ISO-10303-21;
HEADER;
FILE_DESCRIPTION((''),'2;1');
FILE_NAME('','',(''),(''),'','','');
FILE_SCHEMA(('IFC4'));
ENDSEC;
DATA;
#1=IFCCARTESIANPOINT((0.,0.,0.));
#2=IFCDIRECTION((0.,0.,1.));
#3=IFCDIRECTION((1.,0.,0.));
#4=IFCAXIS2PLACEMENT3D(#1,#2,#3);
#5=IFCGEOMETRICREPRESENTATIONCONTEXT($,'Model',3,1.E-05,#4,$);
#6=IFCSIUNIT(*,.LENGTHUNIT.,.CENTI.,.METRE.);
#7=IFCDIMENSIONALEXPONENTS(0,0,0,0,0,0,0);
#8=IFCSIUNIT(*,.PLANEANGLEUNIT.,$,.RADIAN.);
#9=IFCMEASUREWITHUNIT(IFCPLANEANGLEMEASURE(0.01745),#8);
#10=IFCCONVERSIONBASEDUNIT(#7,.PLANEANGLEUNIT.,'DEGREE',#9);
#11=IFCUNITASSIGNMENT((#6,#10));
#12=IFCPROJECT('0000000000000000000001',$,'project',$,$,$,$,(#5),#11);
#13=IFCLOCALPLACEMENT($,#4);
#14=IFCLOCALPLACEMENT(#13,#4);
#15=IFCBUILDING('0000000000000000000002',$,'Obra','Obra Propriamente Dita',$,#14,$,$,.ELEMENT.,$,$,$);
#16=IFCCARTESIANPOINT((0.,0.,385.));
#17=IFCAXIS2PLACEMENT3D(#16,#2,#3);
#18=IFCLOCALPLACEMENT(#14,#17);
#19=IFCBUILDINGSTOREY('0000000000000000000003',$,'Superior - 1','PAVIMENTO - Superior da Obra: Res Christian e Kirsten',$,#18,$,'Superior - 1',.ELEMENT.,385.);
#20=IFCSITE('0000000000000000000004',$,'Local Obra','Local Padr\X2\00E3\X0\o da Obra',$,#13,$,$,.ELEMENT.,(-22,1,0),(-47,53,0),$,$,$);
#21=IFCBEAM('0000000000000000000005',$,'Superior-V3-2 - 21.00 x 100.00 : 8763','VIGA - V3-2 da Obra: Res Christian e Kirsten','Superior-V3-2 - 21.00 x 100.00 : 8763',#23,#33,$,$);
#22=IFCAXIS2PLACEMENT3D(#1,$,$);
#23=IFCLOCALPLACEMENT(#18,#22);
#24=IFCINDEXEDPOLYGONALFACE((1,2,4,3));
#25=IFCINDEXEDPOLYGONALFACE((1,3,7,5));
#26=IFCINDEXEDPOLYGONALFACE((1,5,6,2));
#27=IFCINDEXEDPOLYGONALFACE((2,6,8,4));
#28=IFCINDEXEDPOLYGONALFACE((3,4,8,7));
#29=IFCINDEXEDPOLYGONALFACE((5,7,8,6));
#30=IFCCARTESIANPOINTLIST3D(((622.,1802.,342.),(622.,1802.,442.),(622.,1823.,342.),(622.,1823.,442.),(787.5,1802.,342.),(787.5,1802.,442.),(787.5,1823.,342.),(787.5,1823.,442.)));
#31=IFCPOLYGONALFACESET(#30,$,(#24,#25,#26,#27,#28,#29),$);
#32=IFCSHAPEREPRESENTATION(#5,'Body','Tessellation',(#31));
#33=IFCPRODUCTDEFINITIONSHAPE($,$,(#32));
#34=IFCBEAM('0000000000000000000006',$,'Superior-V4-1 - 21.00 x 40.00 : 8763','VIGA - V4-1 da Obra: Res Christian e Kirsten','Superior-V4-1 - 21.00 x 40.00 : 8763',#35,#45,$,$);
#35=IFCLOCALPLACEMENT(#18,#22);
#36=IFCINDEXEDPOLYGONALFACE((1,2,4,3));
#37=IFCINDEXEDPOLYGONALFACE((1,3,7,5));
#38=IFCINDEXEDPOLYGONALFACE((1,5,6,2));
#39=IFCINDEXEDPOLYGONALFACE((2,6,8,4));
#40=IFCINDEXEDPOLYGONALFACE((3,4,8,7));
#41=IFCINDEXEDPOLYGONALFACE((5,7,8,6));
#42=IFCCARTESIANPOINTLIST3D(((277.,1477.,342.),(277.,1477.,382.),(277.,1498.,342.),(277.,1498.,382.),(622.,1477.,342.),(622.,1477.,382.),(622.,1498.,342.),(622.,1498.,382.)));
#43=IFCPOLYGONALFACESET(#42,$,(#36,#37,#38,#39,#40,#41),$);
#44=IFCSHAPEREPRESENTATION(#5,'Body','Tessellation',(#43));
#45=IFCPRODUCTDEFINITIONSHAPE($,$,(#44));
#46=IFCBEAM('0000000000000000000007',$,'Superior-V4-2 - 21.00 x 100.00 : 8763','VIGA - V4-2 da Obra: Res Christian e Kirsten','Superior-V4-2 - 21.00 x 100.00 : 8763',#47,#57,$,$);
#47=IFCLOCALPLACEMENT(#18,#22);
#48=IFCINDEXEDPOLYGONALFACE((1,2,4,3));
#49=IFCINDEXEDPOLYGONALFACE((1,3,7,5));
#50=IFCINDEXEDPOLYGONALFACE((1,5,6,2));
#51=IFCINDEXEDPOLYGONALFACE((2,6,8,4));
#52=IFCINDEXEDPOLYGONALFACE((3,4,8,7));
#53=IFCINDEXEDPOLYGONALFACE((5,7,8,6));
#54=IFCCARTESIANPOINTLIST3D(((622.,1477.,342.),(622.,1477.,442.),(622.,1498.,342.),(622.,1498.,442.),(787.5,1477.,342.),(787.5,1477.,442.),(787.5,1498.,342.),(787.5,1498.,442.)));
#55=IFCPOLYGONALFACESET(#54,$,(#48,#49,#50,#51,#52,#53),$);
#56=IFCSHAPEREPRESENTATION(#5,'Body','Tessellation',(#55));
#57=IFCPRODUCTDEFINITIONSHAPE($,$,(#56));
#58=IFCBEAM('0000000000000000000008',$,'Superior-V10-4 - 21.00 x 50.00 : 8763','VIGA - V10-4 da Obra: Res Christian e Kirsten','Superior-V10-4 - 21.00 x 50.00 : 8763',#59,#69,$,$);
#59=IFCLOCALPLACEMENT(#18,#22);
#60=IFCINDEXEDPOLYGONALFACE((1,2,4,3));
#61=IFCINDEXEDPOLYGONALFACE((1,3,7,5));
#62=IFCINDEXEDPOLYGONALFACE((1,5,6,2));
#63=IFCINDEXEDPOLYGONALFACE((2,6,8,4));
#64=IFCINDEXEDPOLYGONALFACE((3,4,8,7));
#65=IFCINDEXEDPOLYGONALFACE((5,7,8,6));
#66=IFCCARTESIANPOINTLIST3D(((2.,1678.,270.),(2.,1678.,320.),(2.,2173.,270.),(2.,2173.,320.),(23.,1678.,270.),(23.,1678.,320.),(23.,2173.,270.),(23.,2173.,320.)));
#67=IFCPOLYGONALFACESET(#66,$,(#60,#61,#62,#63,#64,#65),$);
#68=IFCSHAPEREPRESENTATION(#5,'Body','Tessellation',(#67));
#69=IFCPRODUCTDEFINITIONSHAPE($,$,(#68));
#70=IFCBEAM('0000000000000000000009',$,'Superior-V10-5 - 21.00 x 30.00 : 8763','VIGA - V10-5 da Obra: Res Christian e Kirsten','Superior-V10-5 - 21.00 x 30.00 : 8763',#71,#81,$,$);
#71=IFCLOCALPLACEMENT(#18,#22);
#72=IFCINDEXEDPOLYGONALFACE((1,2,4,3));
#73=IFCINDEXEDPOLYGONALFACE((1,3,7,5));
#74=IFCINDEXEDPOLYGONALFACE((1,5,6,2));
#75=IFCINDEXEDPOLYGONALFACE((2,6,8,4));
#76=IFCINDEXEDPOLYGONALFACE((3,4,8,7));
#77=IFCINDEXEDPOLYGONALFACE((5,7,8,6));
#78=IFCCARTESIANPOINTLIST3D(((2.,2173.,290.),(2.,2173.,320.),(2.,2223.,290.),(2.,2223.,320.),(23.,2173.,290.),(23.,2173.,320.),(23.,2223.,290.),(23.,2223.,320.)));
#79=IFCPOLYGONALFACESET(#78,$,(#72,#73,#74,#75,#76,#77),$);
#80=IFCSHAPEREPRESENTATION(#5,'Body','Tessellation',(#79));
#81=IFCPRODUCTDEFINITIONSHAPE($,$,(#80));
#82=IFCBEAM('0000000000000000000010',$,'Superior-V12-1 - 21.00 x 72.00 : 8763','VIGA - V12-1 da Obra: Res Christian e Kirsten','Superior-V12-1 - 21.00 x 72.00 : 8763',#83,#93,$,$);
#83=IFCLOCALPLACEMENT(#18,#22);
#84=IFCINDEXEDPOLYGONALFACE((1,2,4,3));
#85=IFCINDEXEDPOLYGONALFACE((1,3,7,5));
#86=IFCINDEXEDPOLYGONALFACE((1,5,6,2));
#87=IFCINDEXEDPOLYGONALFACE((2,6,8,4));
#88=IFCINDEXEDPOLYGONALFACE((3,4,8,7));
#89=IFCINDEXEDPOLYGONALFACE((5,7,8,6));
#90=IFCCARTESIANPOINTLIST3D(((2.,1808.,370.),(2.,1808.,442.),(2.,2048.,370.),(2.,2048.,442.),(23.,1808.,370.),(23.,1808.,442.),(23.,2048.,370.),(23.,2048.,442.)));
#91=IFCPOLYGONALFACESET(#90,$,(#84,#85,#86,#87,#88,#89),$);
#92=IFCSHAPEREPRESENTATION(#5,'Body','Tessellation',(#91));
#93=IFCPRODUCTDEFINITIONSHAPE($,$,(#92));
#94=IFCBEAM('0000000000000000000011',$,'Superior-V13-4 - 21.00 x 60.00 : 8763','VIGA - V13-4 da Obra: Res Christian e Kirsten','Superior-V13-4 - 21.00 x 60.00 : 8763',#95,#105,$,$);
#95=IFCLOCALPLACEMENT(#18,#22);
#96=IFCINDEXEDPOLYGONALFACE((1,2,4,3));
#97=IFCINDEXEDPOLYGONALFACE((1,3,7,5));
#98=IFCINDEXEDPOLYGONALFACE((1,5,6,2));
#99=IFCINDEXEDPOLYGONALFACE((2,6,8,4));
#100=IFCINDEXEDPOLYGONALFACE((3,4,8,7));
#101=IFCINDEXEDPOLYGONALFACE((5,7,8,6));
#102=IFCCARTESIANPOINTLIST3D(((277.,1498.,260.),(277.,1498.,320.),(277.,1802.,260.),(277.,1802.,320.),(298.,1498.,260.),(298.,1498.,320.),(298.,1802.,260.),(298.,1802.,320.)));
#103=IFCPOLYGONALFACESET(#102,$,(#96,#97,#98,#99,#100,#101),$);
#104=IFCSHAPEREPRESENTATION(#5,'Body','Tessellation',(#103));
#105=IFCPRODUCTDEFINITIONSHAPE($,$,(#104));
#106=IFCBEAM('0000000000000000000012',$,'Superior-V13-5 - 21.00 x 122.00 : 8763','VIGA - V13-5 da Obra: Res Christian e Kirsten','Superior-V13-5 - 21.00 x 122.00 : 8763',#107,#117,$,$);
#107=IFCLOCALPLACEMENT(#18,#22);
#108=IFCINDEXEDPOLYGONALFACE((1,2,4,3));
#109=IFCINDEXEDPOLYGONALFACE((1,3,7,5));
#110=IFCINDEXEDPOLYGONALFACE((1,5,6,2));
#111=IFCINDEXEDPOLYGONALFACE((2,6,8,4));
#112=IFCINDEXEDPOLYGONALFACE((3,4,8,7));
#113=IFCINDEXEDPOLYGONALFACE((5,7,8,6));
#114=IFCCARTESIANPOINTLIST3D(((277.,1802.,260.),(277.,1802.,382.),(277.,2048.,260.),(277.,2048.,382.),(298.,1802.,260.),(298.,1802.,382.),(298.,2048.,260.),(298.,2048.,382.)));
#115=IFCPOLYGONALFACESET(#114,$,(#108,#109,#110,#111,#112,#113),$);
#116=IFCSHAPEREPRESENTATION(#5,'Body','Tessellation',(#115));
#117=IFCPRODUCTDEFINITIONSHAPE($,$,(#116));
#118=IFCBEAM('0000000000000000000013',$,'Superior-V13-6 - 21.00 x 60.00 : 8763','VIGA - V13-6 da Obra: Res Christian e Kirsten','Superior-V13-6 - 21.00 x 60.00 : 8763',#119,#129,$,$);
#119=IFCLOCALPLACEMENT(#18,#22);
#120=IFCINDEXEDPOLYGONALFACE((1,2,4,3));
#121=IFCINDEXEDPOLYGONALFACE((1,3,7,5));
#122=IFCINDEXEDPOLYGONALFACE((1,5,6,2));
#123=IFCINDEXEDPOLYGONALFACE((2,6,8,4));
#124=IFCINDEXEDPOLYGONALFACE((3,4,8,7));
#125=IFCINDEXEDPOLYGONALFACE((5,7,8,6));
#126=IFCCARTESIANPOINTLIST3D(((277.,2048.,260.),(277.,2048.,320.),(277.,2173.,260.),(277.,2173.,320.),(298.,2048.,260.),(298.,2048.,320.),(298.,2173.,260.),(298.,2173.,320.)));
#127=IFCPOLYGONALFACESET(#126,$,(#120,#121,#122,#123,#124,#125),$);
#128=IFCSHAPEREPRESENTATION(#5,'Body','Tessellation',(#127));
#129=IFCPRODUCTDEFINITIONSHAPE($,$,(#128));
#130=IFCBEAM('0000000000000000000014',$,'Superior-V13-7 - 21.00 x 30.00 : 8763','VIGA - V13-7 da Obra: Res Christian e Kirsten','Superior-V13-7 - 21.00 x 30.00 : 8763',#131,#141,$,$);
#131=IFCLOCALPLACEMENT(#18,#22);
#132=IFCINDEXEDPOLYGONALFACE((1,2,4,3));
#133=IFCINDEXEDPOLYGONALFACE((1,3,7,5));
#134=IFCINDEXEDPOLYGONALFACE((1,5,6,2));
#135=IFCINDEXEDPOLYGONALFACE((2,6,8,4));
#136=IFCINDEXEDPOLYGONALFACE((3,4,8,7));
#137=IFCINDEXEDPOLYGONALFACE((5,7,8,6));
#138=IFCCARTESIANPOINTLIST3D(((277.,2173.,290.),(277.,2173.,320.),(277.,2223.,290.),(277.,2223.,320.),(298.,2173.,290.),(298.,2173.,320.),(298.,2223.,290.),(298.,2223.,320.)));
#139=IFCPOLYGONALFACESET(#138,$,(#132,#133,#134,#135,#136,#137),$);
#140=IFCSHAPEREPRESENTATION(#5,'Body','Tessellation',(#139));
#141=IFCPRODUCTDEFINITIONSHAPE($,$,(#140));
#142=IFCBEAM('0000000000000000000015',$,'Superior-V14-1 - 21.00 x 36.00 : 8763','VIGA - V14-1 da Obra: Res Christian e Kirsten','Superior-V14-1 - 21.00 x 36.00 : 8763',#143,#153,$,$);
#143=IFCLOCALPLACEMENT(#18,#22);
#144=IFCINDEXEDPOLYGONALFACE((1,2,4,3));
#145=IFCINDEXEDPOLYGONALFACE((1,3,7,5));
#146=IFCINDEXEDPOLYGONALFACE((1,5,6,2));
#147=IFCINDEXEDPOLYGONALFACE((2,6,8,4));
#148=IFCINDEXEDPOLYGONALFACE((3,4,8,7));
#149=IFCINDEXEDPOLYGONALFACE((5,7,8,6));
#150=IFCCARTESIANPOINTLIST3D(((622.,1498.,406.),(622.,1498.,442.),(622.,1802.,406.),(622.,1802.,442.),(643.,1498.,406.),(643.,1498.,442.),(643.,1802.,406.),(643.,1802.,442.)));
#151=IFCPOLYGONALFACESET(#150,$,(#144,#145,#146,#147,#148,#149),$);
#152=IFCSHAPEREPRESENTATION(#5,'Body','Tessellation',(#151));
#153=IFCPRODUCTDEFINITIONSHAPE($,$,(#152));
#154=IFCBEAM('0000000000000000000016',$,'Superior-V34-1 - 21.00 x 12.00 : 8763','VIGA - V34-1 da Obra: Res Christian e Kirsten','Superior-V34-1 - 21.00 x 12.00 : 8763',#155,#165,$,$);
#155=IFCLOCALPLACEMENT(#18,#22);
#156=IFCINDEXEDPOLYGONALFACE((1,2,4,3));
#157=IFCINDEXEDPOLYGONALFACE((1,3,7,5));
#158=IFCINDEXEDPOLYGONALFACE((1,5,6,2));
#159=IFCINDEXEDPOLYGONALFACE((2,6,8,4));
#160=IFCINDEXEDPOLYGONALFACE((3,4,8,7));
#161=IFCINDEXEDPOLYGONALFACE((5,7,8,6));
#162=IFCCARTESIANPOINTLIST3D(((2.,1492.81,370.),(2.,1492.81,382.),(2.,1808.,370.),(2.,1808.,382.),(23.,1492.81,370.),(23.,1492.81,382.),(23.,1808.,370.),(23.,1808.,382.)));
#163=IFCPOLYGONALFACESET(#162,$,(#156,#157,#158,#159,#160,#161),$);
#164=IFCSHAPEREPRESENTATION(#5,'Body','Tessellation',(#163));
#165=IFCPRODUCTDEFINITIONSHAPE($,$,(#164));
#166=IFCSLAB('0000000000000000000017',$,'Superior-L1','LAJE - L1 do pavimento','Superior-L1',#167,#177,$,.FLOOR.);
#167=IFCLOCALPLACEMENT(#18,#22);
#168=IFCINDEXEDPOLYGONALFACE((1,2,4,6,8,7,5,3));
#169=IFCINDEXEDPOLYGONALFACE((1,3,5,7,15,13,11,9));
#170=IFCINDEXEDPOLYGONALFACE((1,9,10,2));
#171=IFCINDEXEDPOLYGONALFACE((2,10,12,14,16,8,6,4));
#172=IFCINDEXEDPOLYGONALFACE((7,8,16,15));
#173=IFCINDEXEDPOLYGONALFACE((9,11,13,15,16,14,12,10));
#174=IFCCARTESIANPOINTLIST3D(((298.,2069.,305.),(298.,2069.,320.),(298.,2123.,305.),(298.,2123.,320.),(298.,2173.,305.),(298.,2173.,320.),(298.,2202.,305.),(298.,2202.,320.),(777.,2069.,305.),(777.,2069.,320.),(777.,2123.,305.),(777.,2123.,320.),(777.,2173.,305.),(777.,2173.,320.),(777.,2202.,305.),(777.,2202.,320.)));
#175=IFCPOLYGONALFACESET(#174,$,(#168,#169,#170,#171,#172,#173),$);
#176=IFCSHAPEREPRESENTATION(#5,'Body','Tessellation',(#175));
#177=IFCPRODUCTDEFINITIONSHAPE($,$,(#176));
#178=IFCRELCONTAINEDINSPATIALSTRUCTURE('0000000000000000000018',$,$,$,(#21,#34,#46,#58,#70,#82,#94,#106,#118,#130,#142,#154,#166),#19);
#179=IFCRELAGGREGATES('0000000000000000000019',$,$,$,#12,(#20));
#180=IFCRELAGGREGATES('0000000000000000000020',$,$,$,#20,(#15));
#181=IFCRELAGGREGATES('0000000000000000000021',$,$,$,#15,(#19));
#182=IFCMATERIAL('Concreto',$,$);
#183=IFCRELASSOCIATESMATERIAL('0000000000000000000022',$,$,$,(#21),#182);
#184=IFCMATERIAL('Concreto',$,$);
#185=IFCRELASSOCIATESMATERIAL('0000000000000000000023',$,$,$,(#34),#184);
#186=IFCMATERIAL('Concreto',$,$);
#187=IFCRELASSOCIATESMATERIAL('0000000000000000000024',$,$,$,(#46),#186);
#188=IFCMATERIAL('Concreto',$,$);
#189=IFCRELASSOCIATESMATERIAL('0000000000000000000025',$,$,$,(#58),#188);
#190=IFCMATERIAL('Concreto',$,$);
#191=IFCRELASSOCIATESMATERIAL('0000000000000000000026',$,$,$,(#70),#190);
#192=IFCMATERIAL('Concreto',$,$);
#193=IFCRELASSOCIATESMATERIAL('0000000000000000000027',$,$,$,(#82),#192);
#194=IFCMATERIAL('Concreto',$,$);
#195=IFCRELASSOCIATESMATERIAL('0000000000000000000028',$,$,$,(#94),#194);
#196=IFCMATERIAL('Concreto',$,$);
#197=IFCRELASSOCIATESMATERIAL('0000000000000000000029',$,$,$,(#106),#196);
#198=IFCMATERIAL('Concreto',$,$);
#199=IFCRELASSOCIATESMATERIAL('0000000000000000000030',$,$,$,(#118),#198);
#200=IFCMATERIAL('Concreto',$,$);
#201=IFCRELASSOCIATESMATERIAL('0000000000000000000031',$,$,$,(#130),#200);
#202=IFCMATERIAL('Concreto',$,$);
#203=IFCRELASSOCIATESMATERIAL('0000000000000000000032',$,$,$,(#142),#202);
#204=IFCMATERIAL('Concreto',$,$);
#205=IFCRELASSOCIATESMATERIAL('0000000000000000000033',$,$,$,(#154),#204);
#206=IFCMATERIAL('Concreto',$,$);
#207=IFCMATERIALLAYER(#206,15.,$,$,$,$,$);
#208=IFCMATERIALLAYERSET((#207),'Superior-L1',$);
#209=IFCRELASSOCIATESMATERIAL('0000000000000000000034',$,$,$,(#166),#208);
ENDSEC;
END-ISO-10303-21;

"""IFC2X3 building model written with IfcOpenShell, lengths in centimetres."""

from ifc_helpers import new_model, entity, si_unit, converted_unit, frame, origin_with_axes, place, context, project, spatial, polyline, outline, extrude, material, layer, layer_set, layer_usage, element, save


model = new_model("IFC2X3")

# Units and contexts
model_context = context("Model", 3, precision=1e-05, world=origin_with_axes())
ifc_project = project(units=[si_unit("LENGTHUNIT", "METRE", prefix="CENTI"), converted_unit("PLANEANGLEUNIT", "DEGREE", entity("IfcPlaneAngleMeasure", 0.01745), si_unit("PLANEANGLEUNIT", "RADIAN"), dimensions=[0, 0, 0, 0, 0, 0, 0])], contexts=[model_context])

# Site, building, storey
site_placement = place(None, origin_with_axes())
site = spatial("IfcSite", under=ifc_project, at=site_placement, Name="Local Obra", Description="Local Padrão da Obra", CompositionType="ELEMENT", RefLatitude=(-22, 1, 0), RefLongitude=(-47, 53, 0))
building_placement = place(site_placement, origin_with_axes())
building = spatial("IfcBuilding", under=site, at=building_placement, Name="Obra", Description="Obra Propriamente Dita", CompositionType="ELEMENT")
storey_placement = place(building_placement, frame((0.0, 0.0, 385.0), z_axis=(0.0, 0.0, 1.0), x_axis=(1.0, 0.0, 0.0)))
storey = spatial("IfcBuildingStorey", under=building, at=storey_placement, Name="Superior - 1", Description="PAVIMENTO - Superior da Obra: Res Christian e Kirsten", LongName="Superior - 1", CompositionType="ELEMENT", Elevation=385.0)

# Beams
ifc_material_1 = material(Name="Concreto")
beam_1_placement = place(storey_placement, frame((622.0, 1802.0, 442.0), z_axis=(1.0, 0.0, 0.0), x_axis=(0.0, -1.0, 0.0)))
element("IfcBeam", 1, at=beam_1_placement, inside=storey, material=ifc_material_1, Name="Superior-V3-2 - 21.00 x 100.00 : 8763", Description="VIGA - V3-2 da Obra: Res Christian e Kirsten", ObjectType="Superior-V3-2 - 21.00 x 100.00 : 8763", context=model_context, shape_type="SweptSolid", body=[
    extrude(outline(polyline([(-21.0, 0.0), (0.0, 0.0), (0.0, 100.0), (-21.0, 100.0), (-21.0, 0.0)])), origin_with_axes(), (0.0, 0.0, 1.0), 165.5),
])
ifc_material_2 = material(Name="Concreto")
beam_2_placement = place(storey_placement, frame((277.0, 1498.0, 382.0), z_axis=(1.0, 0.0, 0.0), x_axis=(0.0, -1.0, 0.0)))
element("IfcBeam", 2, at=beam_2_placement, inside=storey, material=ifc_material_2, Name="Superior-V4-1 - 21.00 x 40.00 : 8763", Description="VIGA - V4-1 da Obra: Res Christian e Kirsten", ObjectType="Superior-V4-1 - 21.00 x 40.00 : 8763", context=model_context, shape_type="SweptSolid", body=[
    extrude(outline(polyline([(0.0, 0.0), (21.0, 0.0), (21.0, 40.0), (0.0, 40.0), (0.0, 0.0)])), origin_with_axes(), (0.0, 0.0, 1.0), 345.0),
])
ifc_material_3 = material(Name="Concreto")
beam_3_placement = place(storey_placement, frame((622.0, 1498.0, 442.0), z_axis=(1.0, 0.0, 0.0), x_axis=(0.0, -1.0, 0.0)))
element("IfcBeam", 3, at=beam_3_placement, inside=storey, material=ifc_material_3, Name="Superior-V4-2 - 21.00 x 100.00 : 8763", Description="VIGA - V4-2 da Obra: Res Christian e Kirsten", ObjectType="Superior-V4-2 - 21.00 x 100.00 : 8763", context=model_context, shape_type="SweptSolid", body=[
    extrude(outline(polyline([(0.0, 0.0), (21.0, 0.0), (21.0, 100.0), (0.0, 100.0), (0.0, 0.0)])), origin_with_axes(), (0.0, 0.0, 1.0), 165.5),
])
ifc_material_4 = material(Name="Concreto")
beam_4_placement = place(storey_placement, frame((2.0, 1678.0, 320.0), z_axis=(0.0, 1.0, 0.0), x_axis=(1.0, 0.0, 0.0)))
element("IfcBeam", 4, at=beam_4_placement, inside=storey, material=ifc_material_4, Name="Superior-V10-4 - 21.00 x 50.00 : 8763", Description="VIGA - V10-4 da Obra: Res Christian e Kirsten", ObjectType="Superior-V10-4 - 21.00 x 50.00 : 8763", context=model_context, shape_type="SweptSolid", body=[
    extrude(outline(polyline([(0.0, 0.0), (21.0, 0.0), (21.0, 50.0), (0.0, 50.0), (0.0, 0.0)])), origin_with_axes(), (0.0, 0.0, 1.0), 495.0),
])
ifc_material_5 = material(Name="Concreto")
beam_5_placement = place(storey_placement, frame((2.0, 2173.0, 320.0), z_axis=(0.0, 1.0, 0.0), x_axis=(1.0, 0.0, 0.0)))
element("IfcBeam", 5, at=beam_5_placement, inside=storey, material=ifc_material_5, Name="Superior-V10-5 - 21.00 x 30.00 : 8763", Description="VIGA - V10-5 da Obra: Res Christian e Kirsten", ObjectType="Superior-V10-5 - 21.00 x 30.00 : 8763", context=model_context, shape_type="SweptSolid", body=[
    extrude(outline(polyline([(0.0, 0.0), (21.0, 0.0), (21.0, 30.0), (0.0, 30.0), (0.0, 0.0)])), origin_with_axes(), (0.0, 0.0, 1.0), 50.0),
])
ifc_material_6 = material(Name="Concreto")
beam_6_placement = place(storey_placement, frame((2.0, 1808.0, 442.0), z_axis=(0.000002, 1.0, 0.0), x_axis=(1.0, -0.000002, 0.0)))
element("IfcBeam", 6, at=beam_6_placement, inside=storey, material=ifc_material_6, Name="Superior-V12-1 - 21.00 x 72.00 : 8763", Description="VIGA - V12-1 da Obra: Res Christian e Kirsten", ObjectType="Superior-V12-1 - 21.00 x 72.00 : 8763", context=model_context, shape_type="SweptSolid", body=[
    extrude(outline(polyline([(0.0, 0.0), (21.0, 0.0), (21.0, 72.0), (0.0, 72.0), (0.0, 0.0)])), origin_with_axes(), (0.0, 0.0, 1.0), 240.0),
])
ifc_material_7 = material(Name="Concreto")
beam_7_placement = place(storey_placement, frame((277.0, 1498.0, 320.0), z_axis=(0.0, 1.0, 0.0), x_axis=(1.0, 0.0, 0.0)))
element("IfcBeam", 7, at=beam_7_placement, inside=storey, material=ifc_material_7, Name="Superior-V13-4 - 21.00 x 60.00 : 8763", Description="VIGA - V13-4 da Obra: Res Christian e Kirsten", ObjectType="Superior-V13-4 - 21.00 x 60.00 : 8763", context=model_context, shape_type="SweptSolid", body=[
    extrude(outline(polyline([(0.0, 0.0), (21.0, 0.0), (21.0, 60.0), (0.0, 60.0), (0.0, 0.0)])), origin_with_axes(), (0.0, 0.0, 1.0), 304.0),
])
ifc_material_8 = material(Name="Concreto")
beam_8_placement = place(storey_placement, frame((277.0, 1802.0, 382.0), z_axis=(0.0, 1.0, 0.0), x_axis=(1.0, 0.0, 0.0)))
element("IfcBeam", 8, at=beam_8_placement, inside=storey, material=ifc_material_8, Name="Superior-V13-5 - 21.00 x 122.00 : 8763", Description="VIGA - V13-5 da Obra: Res Christian e Kirsten", ObjectType="Superior-V13-5 - 21.00 x 122.00 : 8763", context=model_context, shape_type="SweptSolid", body=[
    extrude(outline(polyline([(0.0, 0.0), (21.0, 0.0), (21.0, 122.0), (0.0, 122.0), (0.0, 0.0)])), origin_with_axes(), (0.0, 0.0, 1.0), 246.0),
])
ifc_material_9 = material(Name="Concreto")
beam_9_placement = place(storey_placement, frame((277.0, 2048.0, 320.0), z_axis=(0.0, 1.0, 0.0), x_axis=(1.0, 0.0, 0.0)))
element("IfcBeam", 9, at=beam_9_placement, inside=storey, material=ifc_material_9, Name="Superior-V13-6 - 21.00 x 60.00 : 8763", Description="VIGA - V13-6 da Obra: Res Christian e Kirsten", ObjectType="Superior-V13-6 - 21.00 x 60.00 : 8763", context=model_context, shape_type="SweptSolid", body=[
    extrude(outline(polyline([(0.0, 0.0), (21.0, 0.0), (21.0, 60.0), (0.0, 60.0), (0.0, 0.0)])), origin_with_axes(), (0.0, 0.0, 1.0), 125.0),
])
ifc_material_10 = material(Name="Concreto")
beam_10_placement = place(storey_placement, frame((277.0, 2173.0, 320.0), z_axis=(0.0, 1.0, 0.0), x_axis=(1.0, 0.0, 0.0)))
element("IfcBeam", 10, at=beam_10_placement, inside=storey, material=ifc_material_10, Name="Superior-V13-7 - 21.00 x 30.00 : 8763", Description="VIGA - V13-7 da Obra: Res Christian e Kirsten", ObjectType="Superior-V13-7 - 21.00 x 30.00 : 8763", context=model_context, shape_type="SweptSolid", body=[
    extrude(outline(polyline([(0.0, 0.0), (21.0, 0.0), (21.0, 30.0), (0.0, 30.0), (0.0, 0.0)])), origin_with_axes(), (0.0, 0.0, 1.0), 50.0),
])
ifc_material_11 = material(Name="Concreto")
beam_11_placement = place(storey_placement, frame((622.0, 1498.0, 442.0), z_axis=(0.0, 1.0, 0.0), x_axis=(1.0, 0.0, 0.0)))
element("IfcBeam", 11, at=beam_11_placement, inside=storey, material=ifc_material_11, Name="Superior-V14-1 - 21.00 x 36.00 : 8763", Description="VIGA - V14-1 da Obra: Res Christian e Kirsten", ObjectType="Superior-V14-1 - 21.00 x 36.00 : 8763", context=model_context, shape_type="SweptSolid", body=[
    extrude(outline(polyline([(0.0, 0.0), (21.0, 0.0), (21.0, 36.0), (0.0, 36.0), (0.0, 0.0)])), origin_with_axes(), (0.0, 0.0, 1.0), 304.0),
])
ifc_material_12 = material(Name="Concreto")
beam_12_placement = place(storey_placement, frame((2.0, 1492.81, 382.0), z_axis=(0.0, 1.0, 0.0), x_axis=(1.0, 0.0, 0.0)))
element("IfcBeam", 12, at=beam_12_placement, inside=storey, material=ifc_material_12, Name="Superior-V34-1 - 21.00 x 12.00 : 8763", Description="VIGA - V34-1 da Obra: Res Christian e Kirsten", ObjectType="Superior-V34-1 - 21.00 x 12.00 : 8763", context=model_context, shape_type="SweptSolid", body=[
    extrude(outline(polyline([(0.0, 0.0), (21.0, 0.0), (21.0, 12.0), (0.0, 12.0), (0.0, 0.0)])), origin_with_axes(), (0.0, 0.0, 1.0), 315.19),
])

# Slab
ifc_material_13 = material(Name="Concreto")
ifc_layer_1 = layer(ifc_material_13, 15.0)
ifc_layer_set_1 = layer_set([ifc_layer_1], Name="Superior-L1")
ifc_layer_usage_1 = layer_usage(ifc_layer_set_1, "AXIS3", "POSITIVE", 0.0)
slab_1_placement = place(storey_placement, frame((777.0, 2173.0, 305.0), z_axis=(0.0, 0.0, 1.0), x_axis=(1.0, 0.0, 0.0)))
element("IfcSlab", 13, at=slab_1_placement, inside=storey, material=ifc_layer_usage_1, Name="Superior-L1", Description="LAJE - L1 do pavimento", ObjectType="Superior-L1", PredefinedType="FLOOR", context=model_context, shape_type="SweptSolid", body=[
    extrude(outline(polyline([(0.0, 29.0), (-479.0, 29.0), (-479.0, 0.0), (-479.0, -50.0), (-479.0, -104.0), (0.0, -104.0), (0.0, -50.0), (0.0, 0.0), (0.0, 29.0)])), origin_with_axes(), (0.0, 0.0, 1.0), 15.0),
])

save(model, "model.ifc")
